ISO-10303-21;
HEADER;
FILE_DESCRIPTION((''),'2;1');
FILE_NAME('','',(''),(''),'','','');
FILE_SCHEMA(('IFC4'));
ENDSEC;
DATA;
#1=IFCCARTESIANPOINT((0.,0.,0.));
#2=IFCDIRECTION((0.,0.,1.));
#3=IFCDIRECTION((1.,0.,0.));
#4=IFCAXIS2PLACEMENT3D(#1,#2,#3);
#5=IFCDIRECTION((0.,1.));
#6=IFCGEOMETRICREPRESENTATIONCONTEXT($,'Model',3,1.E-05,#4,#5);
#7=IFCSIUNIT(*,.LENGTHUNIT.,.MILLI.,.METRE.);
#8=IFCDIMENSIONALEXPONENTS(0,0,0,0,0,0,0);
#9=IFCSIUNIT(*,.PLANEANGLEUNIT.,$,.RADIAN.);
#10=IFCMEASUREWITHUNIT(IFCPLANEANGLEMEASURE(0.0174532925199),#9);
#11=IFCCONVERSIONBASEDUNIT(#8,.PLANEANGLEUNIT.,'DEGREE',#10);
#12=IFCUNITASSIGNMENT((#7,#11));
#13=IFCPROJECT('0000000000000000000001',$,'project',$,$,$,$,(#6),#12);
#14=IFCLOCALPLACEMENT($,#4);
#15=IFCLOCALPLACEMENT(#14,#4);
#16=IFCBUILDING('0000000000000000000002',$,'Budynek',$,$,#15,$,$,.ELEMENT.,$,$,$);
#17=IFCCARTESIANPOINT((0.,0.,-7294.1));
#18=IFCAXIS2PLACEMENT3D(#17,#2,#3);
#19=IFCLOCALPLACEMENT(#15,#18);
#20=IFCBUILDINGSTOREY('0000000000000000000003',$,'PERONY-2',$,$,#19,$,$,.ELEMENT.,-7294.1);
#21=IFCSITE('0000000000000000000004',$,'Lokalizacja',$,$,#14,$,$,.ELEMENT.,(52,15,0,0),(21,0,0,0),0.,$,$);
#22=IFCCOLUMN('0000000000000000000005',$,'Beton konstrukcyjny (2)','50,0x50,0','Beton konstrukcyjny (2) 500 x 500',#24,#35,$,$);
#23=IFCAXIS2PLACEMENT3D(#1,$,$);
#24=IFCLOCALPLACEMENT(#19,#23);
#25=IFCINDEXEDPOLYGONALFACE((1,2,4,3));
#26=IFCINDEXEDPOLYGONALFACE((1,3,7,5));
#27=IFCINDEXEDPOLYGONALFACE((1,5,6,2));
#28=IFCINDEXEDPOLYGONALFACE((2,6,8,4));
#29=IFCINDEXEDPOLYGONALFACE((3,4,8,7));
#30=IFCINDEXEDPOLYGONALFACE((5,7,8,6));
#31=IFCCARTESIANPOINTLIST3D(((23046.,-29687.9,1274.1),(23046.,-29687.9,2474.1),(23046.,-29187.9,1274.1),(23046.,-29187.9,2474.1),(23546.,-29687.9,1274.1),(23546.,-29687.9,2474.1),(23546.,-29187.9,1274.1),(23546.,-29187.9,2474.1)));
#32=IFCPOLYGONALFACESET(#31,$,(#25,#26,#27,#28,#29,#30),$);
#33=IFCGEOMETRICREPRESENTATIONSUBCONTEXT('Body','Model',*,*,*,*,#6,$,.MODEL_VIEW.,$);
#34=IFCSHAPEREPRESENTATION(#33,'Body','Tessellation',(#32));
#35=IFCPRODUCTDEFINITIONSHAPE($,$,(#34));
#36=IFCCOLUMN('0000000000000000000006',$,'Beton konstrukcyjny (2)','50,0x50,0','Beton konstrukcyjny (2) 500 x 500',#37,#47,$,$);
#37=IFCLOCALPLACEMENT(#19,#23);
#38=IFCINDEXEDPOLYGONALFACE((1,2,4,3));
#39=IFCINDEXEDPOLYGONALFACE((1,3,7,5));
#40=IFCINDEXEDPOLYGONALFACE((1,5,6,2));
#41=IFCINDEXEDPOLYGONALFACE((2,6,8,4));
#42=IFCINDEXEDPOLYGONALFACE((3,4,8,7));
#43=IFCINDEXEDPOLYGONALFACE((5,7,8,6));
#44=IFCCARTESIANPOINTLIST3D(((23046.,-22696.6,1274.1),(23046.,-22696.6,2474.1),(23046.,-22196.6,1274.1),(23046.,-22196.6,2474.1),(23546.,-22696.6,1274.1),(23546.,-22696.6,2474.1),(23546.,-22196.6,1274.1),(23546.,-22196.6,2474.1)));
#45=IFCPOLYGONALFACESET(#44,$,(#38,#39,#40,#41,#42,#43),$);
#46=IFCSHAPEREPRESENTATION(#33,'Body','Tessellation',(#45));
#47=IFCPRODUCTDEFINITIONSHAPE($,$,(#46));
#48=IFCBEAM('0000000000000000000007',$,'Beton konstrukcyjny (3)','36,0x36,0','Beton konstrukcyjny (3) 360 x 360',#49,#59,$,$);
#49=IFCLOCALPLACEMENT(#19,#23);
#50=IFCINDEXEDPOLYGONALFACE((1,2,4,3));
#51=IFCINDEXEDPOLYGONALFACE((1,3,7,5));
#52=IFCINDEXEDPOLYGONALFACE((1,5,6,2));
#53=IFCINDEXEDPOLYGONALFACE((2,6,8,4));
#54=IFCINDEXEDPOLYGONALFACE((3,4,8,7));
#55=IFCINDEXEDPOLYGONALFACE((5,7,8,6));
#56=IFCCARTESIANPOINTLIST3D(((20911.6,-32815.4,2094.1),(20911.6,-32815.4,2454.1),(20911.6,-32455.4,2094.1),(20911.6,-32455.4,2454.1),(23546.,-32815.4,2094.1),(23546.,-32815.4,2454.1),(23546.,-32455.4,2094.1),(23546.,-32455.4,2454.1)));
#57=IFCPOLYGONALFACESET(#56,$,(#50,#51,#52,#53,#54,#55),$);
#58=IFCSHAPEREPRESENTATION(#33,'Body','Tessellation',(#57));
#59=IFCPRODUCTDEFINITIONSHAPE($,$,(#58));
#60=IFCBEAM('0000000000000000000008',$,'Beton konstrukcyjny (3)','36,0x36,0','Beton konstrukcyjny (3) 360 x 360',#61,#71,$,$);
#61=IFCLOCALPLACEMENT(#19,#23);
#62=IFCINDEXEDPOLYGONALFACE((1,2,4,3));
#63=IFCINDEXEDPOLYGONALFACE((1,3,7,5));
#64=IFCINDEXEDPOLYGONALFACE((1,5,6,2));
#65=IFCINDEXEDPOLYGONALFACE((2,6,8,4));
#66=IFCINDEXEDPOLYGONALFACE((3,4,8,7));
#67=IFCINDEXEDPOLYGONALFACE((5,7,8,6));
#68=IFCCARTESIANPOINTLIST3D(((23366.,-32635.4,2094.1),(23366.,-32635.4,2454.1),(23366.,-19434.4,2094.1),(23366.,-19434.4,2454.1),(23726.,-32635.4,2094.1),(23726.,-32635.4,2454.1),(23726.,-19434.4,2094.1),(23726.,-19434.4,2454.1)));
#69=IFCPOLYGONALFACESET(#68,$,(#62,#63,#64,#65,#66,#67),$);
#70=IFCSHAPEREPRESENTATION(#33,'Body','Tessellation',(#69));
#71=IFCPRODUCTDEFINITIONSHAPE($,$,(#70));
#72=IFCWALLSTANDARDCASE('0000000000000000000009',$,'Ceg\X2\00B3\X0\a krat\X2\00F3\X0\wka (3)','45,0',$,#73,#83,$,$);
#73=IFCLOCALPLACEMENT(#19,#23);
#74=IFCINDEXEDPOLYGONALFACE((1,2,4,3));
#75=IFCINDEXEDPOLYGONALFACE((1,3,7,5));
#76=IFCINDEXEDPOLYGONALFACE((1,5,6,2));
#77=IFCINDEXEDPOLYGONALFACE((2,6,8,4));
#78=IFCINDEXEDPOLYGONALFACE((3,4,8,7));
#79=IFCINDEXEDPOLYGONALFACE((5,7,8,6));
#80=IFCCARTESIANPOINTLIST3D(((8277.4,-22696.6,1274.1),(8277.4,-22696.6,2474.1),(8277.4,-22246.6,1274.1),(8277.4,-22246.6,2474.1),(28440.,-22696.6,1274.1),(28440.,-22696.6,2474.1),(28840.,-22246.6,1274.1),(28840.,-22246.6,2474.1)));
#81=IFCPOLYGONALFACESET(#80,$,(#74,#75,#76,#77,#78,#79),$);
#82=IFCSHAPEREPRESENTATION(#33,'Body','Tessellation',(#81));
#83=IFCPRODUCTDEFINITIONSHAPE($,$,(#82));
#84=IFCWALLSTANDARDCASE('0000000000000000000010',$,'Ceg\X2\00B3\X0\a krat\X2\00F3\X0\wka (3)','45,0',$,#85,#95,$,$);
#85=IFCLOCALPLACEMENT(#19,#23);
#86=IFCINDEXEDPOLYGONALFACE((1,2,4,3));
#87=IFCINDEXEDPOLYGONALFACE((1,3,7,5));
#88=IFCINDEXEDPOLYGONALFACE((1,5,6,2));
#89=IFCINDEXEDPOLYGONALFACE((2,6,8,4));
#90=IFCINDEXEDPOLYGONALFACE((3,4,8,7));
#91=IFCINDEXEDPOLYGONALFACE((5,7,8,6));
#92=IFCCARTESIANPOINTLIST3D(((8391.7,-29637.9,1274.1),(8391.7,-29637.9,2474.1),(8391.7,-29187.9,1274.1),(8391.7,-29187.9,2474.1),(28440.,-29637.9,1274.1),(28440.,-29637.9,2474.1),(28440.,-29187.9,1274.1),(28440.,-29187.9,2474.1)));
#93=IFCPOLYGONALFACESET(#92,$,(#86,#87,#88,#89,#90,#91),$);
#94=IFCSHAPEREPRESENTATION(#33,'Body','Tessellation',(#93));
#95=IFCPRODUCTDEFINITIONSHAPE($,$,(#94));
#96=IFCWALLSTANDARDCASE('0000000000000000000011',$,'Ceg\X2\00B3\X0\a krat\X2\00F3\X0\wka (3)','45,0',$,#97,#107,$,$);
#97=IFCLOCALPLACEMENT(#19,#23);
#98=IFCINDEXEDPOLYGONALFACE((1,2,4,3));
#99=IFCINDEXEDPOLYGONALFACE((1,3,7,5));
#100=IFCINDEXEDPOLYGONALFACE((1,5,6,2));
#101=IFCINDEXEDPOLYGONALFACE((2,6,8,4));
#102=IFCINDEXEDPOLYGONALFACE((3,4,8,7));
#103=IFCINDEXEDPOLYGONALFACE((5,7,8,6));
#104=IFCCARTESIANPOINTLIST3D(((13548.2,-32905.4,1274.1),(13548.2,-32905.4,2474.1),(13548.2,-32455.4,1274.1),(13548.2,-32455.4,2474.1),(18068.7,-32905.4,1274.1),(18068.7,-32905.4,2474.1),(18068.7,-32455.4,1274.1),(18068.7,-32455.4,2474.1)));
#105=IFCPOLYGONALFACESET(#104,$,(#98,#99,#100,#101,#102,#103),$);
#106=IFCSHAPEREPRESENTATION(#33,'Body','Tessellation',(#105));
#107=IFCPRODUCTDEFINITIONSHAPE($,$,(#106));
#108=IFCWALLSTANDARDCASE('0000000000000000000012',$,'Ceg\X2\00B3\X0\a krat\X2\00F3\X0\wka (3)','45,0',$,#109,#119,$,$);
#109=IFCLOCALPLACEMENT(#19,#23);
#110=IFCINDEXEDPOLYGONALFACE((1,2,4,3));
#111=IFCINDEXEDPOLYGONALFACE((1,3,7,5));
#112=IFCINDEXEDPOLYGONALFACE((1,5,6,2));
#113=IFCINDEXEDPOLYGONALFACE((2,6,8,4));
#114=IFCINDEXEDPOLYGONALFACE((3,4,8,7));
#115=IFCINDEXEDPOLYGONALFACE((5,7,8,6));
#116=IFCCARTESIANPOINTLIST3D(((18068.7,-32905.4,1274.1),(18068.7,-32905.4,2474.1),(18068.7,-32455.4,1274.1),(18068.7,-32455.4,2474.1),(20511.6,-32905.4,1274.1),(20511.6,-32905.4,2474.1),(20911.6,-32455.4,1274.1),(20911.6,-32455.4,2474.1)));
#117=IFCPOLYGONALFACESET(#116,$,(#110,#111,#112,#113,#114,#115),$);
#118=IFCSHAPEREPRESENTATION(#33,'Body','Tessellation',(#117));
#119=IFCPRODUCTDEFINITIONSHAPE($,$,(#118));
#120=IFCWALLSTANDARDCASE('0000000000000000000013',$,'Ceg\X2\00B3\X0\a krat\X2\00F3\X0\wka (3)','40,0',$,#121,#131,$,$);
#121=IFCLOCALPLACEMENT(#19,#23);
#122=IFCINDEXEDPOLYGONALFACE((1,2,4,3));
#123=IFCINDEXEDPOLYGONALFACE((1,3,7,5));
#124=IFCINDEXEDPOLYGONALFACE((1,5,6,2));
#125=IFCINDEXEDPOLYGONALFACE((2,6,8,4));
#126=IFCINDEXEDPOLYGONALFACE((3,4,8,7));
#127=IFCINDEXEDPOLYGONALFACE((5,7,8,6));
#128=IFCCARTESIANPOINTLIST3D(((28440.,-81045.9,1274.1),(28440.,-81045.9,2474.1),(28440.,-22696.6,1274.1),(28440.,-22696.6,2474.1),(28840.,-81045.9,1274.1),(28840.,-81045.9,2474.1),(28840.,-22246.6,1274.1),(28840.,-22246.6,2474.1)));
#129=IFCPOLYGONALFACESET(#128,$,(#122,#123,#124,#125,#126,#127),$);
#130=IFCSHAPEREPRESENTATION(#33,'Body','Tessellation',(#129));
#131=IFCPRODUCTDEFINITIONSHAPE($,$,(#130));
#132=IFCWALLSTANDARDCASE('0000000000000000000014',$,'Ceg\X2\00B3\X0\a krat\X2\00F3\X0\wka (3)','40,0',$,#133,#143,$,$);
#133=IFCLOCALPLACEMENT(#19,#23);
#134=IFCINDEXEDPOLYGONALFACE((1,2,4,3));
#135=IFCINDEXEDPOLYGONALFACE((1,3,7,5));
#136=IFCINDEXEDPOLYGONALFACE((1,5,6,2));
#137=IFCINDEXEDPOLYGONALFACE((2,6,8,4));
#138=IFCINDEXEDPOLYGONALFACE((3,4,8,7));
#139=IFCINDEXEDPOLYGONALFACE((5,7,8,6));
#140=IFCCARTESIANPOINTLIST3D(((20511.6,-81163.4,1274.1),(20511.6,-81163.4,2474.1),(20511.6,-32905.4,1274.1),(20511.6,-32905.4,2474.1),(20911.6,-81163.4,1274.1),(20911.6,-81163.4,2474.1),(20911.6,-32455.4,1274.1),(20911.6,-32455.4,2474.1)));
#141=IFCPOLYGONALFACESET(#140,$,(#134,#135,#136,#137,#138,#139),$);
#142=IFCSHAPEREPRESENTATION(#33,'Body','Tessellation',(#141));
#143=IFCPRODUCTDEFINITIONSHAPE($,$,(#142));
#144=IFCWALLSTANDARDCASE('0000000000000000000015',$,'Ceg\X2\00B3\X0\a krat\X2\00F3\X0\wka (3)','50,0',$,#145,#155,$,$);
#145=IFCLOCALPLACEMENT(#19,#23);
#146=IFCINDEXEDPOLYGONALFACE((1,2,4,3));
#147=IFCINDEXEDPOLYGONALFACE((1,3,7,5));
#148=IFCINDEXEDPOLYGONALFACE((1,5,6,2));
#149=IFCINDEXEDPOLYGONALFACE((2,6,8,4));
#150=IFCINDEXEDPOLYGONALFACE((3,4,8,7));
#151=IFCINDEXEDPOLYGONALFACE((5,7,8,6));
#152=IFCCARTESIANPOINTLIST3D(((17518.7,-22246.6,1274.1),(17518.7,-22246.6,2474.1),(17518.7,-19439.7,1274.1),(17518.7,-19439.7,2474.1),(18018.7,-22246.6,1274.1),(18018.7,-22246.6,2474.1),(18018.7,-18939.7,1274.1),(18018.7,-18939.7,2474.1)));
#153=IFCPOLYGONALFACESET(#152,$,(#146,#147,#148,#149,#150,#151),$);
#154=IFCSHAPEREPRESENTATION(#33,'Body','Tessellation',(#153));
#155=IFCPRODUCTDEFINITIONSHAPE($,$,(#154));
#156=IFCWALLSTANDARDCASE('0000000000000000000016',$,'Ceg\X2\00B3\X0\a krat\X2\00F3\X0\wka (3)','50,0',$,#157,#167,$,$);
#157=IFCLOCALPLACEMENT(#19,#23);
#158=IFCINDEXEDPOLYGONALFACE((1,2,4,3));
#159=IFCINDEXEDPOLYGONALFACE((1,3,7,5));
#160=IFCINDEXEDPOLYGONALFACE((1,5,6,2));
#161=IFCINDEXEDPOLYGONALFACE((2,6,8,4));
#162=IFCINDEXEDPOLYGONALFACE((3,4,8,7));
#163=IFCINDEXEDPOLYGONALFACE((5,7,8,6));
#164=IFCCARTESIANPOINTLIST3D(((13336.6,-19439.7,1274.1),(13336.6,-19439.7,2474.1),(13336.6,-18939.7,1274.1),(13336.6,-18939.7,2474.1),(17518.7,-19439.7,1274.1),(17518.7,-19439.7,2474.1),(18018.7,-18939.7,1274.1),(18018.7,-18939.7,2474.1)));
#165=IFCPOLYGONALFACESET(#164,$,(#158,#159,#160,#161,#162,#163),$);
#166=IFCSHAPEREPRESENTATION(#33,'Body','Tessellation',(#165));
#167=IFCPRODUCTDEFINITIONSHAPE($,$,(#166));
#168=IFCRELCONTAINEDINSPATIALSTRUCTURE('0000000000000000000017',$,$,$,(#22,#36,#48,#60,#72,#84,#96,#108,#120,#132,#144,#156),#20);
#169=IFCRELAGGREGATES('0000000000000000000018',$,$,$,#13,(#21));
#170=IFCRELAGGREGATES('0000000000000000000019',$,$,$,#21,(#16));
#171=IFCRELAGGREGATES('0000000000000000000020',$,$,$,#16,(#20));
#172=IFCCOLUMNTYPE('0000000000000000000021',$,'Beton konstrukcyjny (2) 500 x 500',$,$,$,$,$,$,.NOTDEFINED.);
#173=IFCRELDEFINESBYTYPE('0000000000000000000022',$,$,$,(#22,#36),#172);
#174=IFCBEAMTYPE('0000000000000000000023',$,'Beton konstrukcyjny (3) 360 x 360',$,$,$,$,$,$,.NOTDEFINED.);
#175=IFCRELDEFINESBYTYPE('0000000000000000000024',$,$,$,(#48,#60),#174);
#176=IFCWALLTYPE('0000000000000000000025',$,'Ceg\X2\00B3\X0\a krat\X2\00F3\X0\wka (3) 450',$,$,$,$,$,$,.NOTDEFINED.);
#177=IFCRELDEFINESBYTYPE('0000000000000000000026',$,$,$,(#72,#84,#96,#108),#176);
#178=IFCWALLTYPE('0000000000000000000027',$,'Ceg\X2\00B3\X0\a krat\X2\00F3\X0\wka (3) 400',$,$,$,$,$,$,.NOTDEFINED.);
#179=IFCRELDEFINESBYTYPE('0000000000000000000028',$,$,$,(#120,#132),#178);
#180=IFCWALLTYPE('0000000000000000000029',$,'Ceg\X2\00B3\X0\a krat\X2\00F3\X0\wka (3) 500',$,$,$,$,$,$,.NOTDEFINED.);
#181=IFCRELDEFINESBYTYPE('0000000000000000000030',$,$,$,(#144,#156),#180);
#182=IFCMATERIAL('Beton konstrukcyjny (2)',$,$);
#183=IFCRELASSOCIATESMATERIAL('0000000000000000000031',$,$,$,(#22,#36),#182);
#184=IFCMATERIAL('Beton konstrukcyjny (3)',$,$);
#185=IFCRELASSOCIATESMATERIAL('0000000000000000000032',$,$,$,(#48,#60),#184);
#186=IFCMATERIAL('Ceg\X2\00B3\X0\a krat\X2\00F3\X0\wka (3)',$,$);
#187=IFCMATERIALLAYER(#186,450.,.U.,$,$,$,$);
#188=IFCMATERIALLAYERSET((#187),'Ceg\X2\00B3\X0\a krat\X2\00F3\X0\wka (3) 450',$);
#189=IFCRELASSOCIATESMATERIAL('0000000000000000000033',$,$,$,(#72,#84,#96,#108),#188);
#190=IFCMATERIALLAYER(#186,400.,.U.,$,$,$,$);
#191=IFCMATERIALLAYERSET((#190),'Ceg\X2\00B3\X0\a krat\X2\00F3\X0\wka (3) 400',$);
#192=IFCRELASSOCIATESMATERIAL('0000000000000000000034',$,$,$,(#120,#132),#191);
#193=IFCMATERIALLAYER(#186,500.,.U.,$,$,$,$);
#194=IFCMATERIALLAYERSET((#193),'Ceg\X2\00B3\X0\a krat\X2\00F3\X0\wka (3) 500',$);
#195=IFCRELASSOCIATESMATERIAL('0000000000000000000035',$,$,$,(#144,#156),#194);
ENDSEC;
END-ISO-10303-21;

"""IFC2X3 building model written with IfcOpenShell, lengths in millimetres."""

from ifc_helpers import new_model, entity, si_unit, converted_unit, direction, frame, frame_2d, origin_with_axes, origin_2d_with_axis, place, context, subcontext, project, spatial, polyline, rectangle, outline, extrude, material, layer, layer_set, layer_usage, type_object, element, save


model = new_model("IFC2X3")

# Units and contexts
model_context = context("Model", 3, precision=1e-05, world=origin_with_axes(), true_north=direction((0.0, 1.0)))
body_context = subcontext(model_context, "Body", "Model", "MODEL_VIEW")
ifc_project = project(units=[si_unit("LENGTHUNIT", "METRE", prefix="MILLI"), converted_unit("PLANEANGLEUNIT", "DEGREE", entity("IfcPlaneAngleMeasure", 0.0174532925199), si_unit("PLANEANGLEUNIT", "RADIAN"), dimensions=[0, 0, 0, 0, 0, 0, 0])], contexts=[model_context])

# Site, building, storey
site_placement = place(None, origin_with_axes())
site = spatial("IfcSite", under=ifc_project, at=site_placement, Name="Lokalizacja", CompositionType="ELEMENT", RefLatitude=(52, 15, 0, 0), RefLongitude=(21, 0, 0, 0), RefElevation=0.0)
building_placement = place(site_placement, origin_with_axes())
building = spatial("IfcBuilding", under=site, at=building_placement, Name="Budynek", CompositionType="ELEMENT")
storey_placement = place(building_placement, frame((0.0, 0.0, -7294.1), z_axis=(0.0, 0.0, 1.0), x_axis=(1.0, 0.0, 0.0)))
storey = spatial("IfcBuildingStorey", under=building, at=storey_placement, Name="PERONY-2", CompositionType="ELEMENT", Elevation=-7294.1)

# Columns
ifc_material_1 = material(Name="Beton konstrukcyjny (2)")
column_type = type_object("IfcColumnType", Name="Beton konstrukcyjny (2) 500 x 500", PredefinedType="NOTDEFINED")
for number, where, z_axis, x_axis, name in (
    (1, (23296.0, -29437.9, 1274.1), (0.0, 0.0, 1.0), (1.0, 0.0, 0.0), "Beton konstrukcyjny (2)"),
    (2, (23296.0, -22446.6, 1274.1), (0.0, 0.0, 1.0), (1.0, 0.0, 0.0), "Beton konstrukcyjny (2)"),
):
    element("IfcColumn", number, at=place(storey_placement, frame(where, z_axis=z_axis, x_axis=x_axis)), inside=storey, type_object=column_type, material=ifc_material_1, Name=name, Description="50,0x50,0", ObjectType="Beton konstrukcyjny (2) 500 x 500", context=body_context, shape_type="SweptSolid", body=[
        extrude(rectangle(XDim=500.0, YDim=500.0, at=origin_2d_with_axis()), origin_with_axes(), (0.0, 0.0, 1.0), 1200.0),
    ])

# Beams
ifc_material_2 = material(Name="Beton konstrukcyjny (3)")
beam_type = type_object("IfcBeamType", Name="Beton konstrukcyjny (3) 360 x 360", PredefinedType="NOTDEFINED")
beam_1_placement = place(storey_placement, frame((23546.0, -32635.4, 2454.1), z_axis=(0.0, 0.0, 1.0), x_axis=(0.0, 1.0, 0.0)))
element("IfcBeam", 3, at=beam_1_placement, inside=storey, type_object=beam_type, material=ifc_material_2, Name="Beton konstrukcyjny (3)", Description="36,0x36,0", ObjectType="Beton konstrukcyjny (3) 360 x 360", context=body_context, shape_type="SweptSolid", body=[
    extrude(rectangle(XDim=360.0, YDim=360.0, at=frame_2d((-180.0, 0.0), x_axis=(1.0, 0.0))), frame((0.0, 0.0, 0.0), z_axis=(0.0, 1.0, 0.0), x_axis=(0.0, 0.0, 1.0)), (0.0, 0.0, 1.0), 2634.4),
])
beam_2_placement = place(storey_placement, frame((23546.0, -32635.4, 2454.1), z_axis=(0.0, 0.0, 1.0), x_axis=(1.0, 0.0, 0.0)))
element("IfcBeam", 4, at=beam_2_placement, inside=storey, type_object=beam_type, material=ifc_material_2, Name="Beton konstrukcyjny (3)", Description="36,0x36,0", ObjectType="Beton konstrukcyjny (3) 360 x 360", context=body_context, shape_type="SweptSolid", body=[
    extrude(rectangle(XDim=360.0, YDim=360.0, at=frame_2d((-180.0, 0.0), x_axis=(1.0, 0.0))), frame((0.0, 0.0, 0.0), z_axis=(0.0, 1.0, 0.0), x_axis=(0.0, 0.0, 1.0)), (0.0, 0.0, 1.0), 13201.1),
])

# Walls
ifc_material_3 = material(Name="Ceg³a kratówka (3)")
ifc_layer_1 = layer(ifc_material_3, 450.0, ventilated="UNKNOWN")
ifc_layer_set_1 = layer_set([ifc_layer_1], Name="Ceg³a kratówka (3) 450")
ifc_layer_usage_1 = layer_usage(ifc_layer_set_1, "AXIS2", "NEGATIVE", 0.0)
wall_type_1 = type_object("IfcWallType", Name="Ceg³a kratówka (3) 450", PredefinedType="NOTDEFINED")
wall_1_placement = place(storey_placement, frame((28440.0, -22696.6, 1274.1), z_axis=(0.0, 0.0, 1.0), x_axis=(-1.0, 0.0, 0.0)))
element("IfcWallStandardCase", 5, at=wall_1_placement, inside=storey, type_object=wall_type_1, material=ifc_layer_usage_1, Name="Ceg³a kratówka (3)", Description="45,0", context=body_context, shape_type="SweptSolid", body=[
    extrude(outline(polyline([(-400.0, -450.0), (20162.6, -450.0), (20162.6, 0.0), (0.0, 0.0), (-400.0, -450.0)])), origin_with_axes(), (0.0, 0.0, 1.0), 1200.0),
])
ifc_layer_usage_2 = layer_usage(ifc_layer_set_1, "AXIS2", "POSITIVE", 0.0)
wall_2_placement = place(storey_placement, frame((28440.0, -29187.9, 1274.1), z_axis=(0.0, 0.0, 1.0), x_axis=(-1.0, 0.0, 0.0)))
element("IfcWallStandardCase", 6, at=wall_2_placement, inside=storey, type_object=wall_type_1, material=ifc_layer_usage_2, Name="Ceg³a kratówka (3)", Description="45,0", context=body_context, shape_type="SweptSolid", body=[
    extrude(outline(polyline([(0.0, 0.0), (20048.3, 0.0), (20048.3, 450.0), (0.0, 450.0), (0.0, 0.0)])), origin_with_axes(), (0.0, 0.0, 1.0), 1200.0),
])
ifc_layer_usage_3 = layer_usage(ifc_layer_set_1, "AXIS2", "NEGATIVE", 0.0)
wall_3_placement = place(storey_placement, frame((13548.2, -32455.4, 1274.1), z_axis=(0.0, 0.0, 1.0), x_axis=(1.0, 0.0, 0.0)))
element("IfcWallStandardCase", 7, at=wall_3_placement, inside=storey, type_object=wall_type_1, material=ifc_layer_usage_3, Name="Ceg³a kratówka (3)", Description="45,0", context=body_context, shape_type="SweptSolid", body=[
    extrude(outline(polyline([(0.0, -450.0), (4520.5, -450.0), (4520.5, 0.0), (0.0, 0.0), (0.0, -450.0)])), origin_with_axes(), (0.0, 0.0, 1.0), 1200.0),
])
ifc_layer_usage_4 = layer_usage(ifc_layer_set_1, "AXIS2", "NEGATIVE", 0.0)
wall_4_placement = place(storey_placement, frame((18068.7, -32455.4, 1274.1), z_axis=(0.0, 0.0, 1.0), x_axis=(1.0, 0.0, 0.0)))
element("IfcWallStandardCase", 8, at=wall_4_placement, inside=storey, type_object=wall_type_1, material=ifc_layer_usage_4, Name="Ceg³a kratówka (3)", Description="45,0", context=body_context, shape_type="SweptSolid", body=[
    extrude(outline(polyline([(0.0, -450.0), (2442.9, -450.0), (2842.9, 0.0), (0.0, 0.0), (0.0, -450.0)])), origin_with_axes(), (0.0, 0.0, 1.0), 1200.0),
])
ifc_layer_2 = layer(ifc_material_3, 400.0, ventilated="UNKNOWN")
ifc_layer_set_2 = layer_set([ifc_layer_2], Name="Ceg³a kratówka (3) 400")
ifc_layer_usage_5 = layer_usage(ifc_layer_set_2, "AXIS2", "POSITIVE", 0.0)
wall_type_2 = type_object("IfcWallType", Name="Ceg³a kratówka (3) 400", PredefinedType="NOTDEFINED")
wall_5_placement = place(storey_placement, frame((28440.0, -22696.6, 1274.1), z_axis=(0.0, 0.0, 1.0), x_axis=(0.0, -1.0, 0.0)))
element("IfcWallStandardCase", 9, at=wall_5_placement, inside=storey, type_object=wall_type_2, material=ifc_layer_usage_5, Name="Ceg³a kratówka (3)", Description="40,0", context=body_context, shape_type="SweptSolid", body=[
    extrude(outline(polyline([(0.0, 0.0), (58349.3, 0.0), (58349.3, 400.0), (-450.0, 400.0), (0.0, 0.0)])), origin_with_axes(), (0.0, 0.0, 1.0), 1200.0),
])
ifc_layer_usage_6 = layer_usage(ifc_layer_set_2, "AXIS2", "NEGATIVE", 0.0)
wall_6_placement = place(storey_placement, frame((20911.6, -32455.4, 1274.1), z_axis=(0.0, 0.0, 1.0), x_axis=(0.0, -1.0, 0.0)))
element("IfcWallStandardCase", 10, at=wall_6_placement, inside=storey, type_object=wall_type_2, material=ifc_layer_usage_6, Name="Ceg³a kratówka (3)", Description="40,0", context=body_context, shape_type="SweptSolid", body=[
    extrude(outline(polyline([(450.0, -400.0), (48708.0, -400.0), (48708.0, 0.0), (0.0, 0.0), (450.0, -400.0)])), origin_with_axes(), (0.0, 0.0, 1.0), 1200.0),
])
ifc_layer_3 = layer(ifc_material_3, 500.0, ventilated="UNKNOWN")
ifc_layer_set_3 = layer_set([ifc_layer_3], Name="Ceg³a kratówka (3) 500")
ifc_layer_usage_7 = layer_usage(ifc_layer_set_3, "AXIS2", "NEGATIVE", 0.0)
wall_type_3 = type_object("IfcWallType", Name="Ceg³a kratówka (3) 500", PredefinedType="NOTDEFINED")
wall_7_placement = place(storey_placement, frame((18018.7, -18939.7, 1274.1), z_axis=(0.0, 0.0, 1.0), x_axis=(0.0, -1.0, 0.0)))
element("IfcWallStandardCase", 11, at=wall_7_placement, inside=storey, type_object=wall_type_3, material=ifc_layer_usage_7, Name="Ceg³a kratówka (3)", Description="50,0", context=body_context, shape_type="SweptSolid", body=[
    extrude(outline(polyline([(500.0, -500.0), (3306.9, -500.0), (3306.9, 0.0), (0.0, 0.0), (500.0, -500.0)])), origin_with_axes(), (0.0, 0.0, 1.0), 1200.0),
])
ifc_layer_usage_8 = layer_usage(ifc_layer_set_3, "AXIS2", "NEGATIVE", 0.0)
wall_8_placement = place(storey_placement, frame((13336.6, -18939.7, 1274.1), z_axis=(0.0, 0.0, 1.0), x_axis=(1.0, 0.0, 0.0)))
element("IfcWallStandardCase", 12, at=wall_8_placement, inside=storey, type_object=wall_type_3, material=ifc_layer_usage_8, Name="Ceg³a kratówka (3)", Description="50,0", context=body_context, shape_type="SweptSolid", body=[
    extrude(outline(polyline([(0.0, -500.0), (4182.1, -500.0), (4682.1, 0.0), (0.0, 0.0), (0.0, -500.0)])), origin_with_axes(), (0.0, 0.0, 1.0), 1200.0),
])

save(model, "model.ifc")
